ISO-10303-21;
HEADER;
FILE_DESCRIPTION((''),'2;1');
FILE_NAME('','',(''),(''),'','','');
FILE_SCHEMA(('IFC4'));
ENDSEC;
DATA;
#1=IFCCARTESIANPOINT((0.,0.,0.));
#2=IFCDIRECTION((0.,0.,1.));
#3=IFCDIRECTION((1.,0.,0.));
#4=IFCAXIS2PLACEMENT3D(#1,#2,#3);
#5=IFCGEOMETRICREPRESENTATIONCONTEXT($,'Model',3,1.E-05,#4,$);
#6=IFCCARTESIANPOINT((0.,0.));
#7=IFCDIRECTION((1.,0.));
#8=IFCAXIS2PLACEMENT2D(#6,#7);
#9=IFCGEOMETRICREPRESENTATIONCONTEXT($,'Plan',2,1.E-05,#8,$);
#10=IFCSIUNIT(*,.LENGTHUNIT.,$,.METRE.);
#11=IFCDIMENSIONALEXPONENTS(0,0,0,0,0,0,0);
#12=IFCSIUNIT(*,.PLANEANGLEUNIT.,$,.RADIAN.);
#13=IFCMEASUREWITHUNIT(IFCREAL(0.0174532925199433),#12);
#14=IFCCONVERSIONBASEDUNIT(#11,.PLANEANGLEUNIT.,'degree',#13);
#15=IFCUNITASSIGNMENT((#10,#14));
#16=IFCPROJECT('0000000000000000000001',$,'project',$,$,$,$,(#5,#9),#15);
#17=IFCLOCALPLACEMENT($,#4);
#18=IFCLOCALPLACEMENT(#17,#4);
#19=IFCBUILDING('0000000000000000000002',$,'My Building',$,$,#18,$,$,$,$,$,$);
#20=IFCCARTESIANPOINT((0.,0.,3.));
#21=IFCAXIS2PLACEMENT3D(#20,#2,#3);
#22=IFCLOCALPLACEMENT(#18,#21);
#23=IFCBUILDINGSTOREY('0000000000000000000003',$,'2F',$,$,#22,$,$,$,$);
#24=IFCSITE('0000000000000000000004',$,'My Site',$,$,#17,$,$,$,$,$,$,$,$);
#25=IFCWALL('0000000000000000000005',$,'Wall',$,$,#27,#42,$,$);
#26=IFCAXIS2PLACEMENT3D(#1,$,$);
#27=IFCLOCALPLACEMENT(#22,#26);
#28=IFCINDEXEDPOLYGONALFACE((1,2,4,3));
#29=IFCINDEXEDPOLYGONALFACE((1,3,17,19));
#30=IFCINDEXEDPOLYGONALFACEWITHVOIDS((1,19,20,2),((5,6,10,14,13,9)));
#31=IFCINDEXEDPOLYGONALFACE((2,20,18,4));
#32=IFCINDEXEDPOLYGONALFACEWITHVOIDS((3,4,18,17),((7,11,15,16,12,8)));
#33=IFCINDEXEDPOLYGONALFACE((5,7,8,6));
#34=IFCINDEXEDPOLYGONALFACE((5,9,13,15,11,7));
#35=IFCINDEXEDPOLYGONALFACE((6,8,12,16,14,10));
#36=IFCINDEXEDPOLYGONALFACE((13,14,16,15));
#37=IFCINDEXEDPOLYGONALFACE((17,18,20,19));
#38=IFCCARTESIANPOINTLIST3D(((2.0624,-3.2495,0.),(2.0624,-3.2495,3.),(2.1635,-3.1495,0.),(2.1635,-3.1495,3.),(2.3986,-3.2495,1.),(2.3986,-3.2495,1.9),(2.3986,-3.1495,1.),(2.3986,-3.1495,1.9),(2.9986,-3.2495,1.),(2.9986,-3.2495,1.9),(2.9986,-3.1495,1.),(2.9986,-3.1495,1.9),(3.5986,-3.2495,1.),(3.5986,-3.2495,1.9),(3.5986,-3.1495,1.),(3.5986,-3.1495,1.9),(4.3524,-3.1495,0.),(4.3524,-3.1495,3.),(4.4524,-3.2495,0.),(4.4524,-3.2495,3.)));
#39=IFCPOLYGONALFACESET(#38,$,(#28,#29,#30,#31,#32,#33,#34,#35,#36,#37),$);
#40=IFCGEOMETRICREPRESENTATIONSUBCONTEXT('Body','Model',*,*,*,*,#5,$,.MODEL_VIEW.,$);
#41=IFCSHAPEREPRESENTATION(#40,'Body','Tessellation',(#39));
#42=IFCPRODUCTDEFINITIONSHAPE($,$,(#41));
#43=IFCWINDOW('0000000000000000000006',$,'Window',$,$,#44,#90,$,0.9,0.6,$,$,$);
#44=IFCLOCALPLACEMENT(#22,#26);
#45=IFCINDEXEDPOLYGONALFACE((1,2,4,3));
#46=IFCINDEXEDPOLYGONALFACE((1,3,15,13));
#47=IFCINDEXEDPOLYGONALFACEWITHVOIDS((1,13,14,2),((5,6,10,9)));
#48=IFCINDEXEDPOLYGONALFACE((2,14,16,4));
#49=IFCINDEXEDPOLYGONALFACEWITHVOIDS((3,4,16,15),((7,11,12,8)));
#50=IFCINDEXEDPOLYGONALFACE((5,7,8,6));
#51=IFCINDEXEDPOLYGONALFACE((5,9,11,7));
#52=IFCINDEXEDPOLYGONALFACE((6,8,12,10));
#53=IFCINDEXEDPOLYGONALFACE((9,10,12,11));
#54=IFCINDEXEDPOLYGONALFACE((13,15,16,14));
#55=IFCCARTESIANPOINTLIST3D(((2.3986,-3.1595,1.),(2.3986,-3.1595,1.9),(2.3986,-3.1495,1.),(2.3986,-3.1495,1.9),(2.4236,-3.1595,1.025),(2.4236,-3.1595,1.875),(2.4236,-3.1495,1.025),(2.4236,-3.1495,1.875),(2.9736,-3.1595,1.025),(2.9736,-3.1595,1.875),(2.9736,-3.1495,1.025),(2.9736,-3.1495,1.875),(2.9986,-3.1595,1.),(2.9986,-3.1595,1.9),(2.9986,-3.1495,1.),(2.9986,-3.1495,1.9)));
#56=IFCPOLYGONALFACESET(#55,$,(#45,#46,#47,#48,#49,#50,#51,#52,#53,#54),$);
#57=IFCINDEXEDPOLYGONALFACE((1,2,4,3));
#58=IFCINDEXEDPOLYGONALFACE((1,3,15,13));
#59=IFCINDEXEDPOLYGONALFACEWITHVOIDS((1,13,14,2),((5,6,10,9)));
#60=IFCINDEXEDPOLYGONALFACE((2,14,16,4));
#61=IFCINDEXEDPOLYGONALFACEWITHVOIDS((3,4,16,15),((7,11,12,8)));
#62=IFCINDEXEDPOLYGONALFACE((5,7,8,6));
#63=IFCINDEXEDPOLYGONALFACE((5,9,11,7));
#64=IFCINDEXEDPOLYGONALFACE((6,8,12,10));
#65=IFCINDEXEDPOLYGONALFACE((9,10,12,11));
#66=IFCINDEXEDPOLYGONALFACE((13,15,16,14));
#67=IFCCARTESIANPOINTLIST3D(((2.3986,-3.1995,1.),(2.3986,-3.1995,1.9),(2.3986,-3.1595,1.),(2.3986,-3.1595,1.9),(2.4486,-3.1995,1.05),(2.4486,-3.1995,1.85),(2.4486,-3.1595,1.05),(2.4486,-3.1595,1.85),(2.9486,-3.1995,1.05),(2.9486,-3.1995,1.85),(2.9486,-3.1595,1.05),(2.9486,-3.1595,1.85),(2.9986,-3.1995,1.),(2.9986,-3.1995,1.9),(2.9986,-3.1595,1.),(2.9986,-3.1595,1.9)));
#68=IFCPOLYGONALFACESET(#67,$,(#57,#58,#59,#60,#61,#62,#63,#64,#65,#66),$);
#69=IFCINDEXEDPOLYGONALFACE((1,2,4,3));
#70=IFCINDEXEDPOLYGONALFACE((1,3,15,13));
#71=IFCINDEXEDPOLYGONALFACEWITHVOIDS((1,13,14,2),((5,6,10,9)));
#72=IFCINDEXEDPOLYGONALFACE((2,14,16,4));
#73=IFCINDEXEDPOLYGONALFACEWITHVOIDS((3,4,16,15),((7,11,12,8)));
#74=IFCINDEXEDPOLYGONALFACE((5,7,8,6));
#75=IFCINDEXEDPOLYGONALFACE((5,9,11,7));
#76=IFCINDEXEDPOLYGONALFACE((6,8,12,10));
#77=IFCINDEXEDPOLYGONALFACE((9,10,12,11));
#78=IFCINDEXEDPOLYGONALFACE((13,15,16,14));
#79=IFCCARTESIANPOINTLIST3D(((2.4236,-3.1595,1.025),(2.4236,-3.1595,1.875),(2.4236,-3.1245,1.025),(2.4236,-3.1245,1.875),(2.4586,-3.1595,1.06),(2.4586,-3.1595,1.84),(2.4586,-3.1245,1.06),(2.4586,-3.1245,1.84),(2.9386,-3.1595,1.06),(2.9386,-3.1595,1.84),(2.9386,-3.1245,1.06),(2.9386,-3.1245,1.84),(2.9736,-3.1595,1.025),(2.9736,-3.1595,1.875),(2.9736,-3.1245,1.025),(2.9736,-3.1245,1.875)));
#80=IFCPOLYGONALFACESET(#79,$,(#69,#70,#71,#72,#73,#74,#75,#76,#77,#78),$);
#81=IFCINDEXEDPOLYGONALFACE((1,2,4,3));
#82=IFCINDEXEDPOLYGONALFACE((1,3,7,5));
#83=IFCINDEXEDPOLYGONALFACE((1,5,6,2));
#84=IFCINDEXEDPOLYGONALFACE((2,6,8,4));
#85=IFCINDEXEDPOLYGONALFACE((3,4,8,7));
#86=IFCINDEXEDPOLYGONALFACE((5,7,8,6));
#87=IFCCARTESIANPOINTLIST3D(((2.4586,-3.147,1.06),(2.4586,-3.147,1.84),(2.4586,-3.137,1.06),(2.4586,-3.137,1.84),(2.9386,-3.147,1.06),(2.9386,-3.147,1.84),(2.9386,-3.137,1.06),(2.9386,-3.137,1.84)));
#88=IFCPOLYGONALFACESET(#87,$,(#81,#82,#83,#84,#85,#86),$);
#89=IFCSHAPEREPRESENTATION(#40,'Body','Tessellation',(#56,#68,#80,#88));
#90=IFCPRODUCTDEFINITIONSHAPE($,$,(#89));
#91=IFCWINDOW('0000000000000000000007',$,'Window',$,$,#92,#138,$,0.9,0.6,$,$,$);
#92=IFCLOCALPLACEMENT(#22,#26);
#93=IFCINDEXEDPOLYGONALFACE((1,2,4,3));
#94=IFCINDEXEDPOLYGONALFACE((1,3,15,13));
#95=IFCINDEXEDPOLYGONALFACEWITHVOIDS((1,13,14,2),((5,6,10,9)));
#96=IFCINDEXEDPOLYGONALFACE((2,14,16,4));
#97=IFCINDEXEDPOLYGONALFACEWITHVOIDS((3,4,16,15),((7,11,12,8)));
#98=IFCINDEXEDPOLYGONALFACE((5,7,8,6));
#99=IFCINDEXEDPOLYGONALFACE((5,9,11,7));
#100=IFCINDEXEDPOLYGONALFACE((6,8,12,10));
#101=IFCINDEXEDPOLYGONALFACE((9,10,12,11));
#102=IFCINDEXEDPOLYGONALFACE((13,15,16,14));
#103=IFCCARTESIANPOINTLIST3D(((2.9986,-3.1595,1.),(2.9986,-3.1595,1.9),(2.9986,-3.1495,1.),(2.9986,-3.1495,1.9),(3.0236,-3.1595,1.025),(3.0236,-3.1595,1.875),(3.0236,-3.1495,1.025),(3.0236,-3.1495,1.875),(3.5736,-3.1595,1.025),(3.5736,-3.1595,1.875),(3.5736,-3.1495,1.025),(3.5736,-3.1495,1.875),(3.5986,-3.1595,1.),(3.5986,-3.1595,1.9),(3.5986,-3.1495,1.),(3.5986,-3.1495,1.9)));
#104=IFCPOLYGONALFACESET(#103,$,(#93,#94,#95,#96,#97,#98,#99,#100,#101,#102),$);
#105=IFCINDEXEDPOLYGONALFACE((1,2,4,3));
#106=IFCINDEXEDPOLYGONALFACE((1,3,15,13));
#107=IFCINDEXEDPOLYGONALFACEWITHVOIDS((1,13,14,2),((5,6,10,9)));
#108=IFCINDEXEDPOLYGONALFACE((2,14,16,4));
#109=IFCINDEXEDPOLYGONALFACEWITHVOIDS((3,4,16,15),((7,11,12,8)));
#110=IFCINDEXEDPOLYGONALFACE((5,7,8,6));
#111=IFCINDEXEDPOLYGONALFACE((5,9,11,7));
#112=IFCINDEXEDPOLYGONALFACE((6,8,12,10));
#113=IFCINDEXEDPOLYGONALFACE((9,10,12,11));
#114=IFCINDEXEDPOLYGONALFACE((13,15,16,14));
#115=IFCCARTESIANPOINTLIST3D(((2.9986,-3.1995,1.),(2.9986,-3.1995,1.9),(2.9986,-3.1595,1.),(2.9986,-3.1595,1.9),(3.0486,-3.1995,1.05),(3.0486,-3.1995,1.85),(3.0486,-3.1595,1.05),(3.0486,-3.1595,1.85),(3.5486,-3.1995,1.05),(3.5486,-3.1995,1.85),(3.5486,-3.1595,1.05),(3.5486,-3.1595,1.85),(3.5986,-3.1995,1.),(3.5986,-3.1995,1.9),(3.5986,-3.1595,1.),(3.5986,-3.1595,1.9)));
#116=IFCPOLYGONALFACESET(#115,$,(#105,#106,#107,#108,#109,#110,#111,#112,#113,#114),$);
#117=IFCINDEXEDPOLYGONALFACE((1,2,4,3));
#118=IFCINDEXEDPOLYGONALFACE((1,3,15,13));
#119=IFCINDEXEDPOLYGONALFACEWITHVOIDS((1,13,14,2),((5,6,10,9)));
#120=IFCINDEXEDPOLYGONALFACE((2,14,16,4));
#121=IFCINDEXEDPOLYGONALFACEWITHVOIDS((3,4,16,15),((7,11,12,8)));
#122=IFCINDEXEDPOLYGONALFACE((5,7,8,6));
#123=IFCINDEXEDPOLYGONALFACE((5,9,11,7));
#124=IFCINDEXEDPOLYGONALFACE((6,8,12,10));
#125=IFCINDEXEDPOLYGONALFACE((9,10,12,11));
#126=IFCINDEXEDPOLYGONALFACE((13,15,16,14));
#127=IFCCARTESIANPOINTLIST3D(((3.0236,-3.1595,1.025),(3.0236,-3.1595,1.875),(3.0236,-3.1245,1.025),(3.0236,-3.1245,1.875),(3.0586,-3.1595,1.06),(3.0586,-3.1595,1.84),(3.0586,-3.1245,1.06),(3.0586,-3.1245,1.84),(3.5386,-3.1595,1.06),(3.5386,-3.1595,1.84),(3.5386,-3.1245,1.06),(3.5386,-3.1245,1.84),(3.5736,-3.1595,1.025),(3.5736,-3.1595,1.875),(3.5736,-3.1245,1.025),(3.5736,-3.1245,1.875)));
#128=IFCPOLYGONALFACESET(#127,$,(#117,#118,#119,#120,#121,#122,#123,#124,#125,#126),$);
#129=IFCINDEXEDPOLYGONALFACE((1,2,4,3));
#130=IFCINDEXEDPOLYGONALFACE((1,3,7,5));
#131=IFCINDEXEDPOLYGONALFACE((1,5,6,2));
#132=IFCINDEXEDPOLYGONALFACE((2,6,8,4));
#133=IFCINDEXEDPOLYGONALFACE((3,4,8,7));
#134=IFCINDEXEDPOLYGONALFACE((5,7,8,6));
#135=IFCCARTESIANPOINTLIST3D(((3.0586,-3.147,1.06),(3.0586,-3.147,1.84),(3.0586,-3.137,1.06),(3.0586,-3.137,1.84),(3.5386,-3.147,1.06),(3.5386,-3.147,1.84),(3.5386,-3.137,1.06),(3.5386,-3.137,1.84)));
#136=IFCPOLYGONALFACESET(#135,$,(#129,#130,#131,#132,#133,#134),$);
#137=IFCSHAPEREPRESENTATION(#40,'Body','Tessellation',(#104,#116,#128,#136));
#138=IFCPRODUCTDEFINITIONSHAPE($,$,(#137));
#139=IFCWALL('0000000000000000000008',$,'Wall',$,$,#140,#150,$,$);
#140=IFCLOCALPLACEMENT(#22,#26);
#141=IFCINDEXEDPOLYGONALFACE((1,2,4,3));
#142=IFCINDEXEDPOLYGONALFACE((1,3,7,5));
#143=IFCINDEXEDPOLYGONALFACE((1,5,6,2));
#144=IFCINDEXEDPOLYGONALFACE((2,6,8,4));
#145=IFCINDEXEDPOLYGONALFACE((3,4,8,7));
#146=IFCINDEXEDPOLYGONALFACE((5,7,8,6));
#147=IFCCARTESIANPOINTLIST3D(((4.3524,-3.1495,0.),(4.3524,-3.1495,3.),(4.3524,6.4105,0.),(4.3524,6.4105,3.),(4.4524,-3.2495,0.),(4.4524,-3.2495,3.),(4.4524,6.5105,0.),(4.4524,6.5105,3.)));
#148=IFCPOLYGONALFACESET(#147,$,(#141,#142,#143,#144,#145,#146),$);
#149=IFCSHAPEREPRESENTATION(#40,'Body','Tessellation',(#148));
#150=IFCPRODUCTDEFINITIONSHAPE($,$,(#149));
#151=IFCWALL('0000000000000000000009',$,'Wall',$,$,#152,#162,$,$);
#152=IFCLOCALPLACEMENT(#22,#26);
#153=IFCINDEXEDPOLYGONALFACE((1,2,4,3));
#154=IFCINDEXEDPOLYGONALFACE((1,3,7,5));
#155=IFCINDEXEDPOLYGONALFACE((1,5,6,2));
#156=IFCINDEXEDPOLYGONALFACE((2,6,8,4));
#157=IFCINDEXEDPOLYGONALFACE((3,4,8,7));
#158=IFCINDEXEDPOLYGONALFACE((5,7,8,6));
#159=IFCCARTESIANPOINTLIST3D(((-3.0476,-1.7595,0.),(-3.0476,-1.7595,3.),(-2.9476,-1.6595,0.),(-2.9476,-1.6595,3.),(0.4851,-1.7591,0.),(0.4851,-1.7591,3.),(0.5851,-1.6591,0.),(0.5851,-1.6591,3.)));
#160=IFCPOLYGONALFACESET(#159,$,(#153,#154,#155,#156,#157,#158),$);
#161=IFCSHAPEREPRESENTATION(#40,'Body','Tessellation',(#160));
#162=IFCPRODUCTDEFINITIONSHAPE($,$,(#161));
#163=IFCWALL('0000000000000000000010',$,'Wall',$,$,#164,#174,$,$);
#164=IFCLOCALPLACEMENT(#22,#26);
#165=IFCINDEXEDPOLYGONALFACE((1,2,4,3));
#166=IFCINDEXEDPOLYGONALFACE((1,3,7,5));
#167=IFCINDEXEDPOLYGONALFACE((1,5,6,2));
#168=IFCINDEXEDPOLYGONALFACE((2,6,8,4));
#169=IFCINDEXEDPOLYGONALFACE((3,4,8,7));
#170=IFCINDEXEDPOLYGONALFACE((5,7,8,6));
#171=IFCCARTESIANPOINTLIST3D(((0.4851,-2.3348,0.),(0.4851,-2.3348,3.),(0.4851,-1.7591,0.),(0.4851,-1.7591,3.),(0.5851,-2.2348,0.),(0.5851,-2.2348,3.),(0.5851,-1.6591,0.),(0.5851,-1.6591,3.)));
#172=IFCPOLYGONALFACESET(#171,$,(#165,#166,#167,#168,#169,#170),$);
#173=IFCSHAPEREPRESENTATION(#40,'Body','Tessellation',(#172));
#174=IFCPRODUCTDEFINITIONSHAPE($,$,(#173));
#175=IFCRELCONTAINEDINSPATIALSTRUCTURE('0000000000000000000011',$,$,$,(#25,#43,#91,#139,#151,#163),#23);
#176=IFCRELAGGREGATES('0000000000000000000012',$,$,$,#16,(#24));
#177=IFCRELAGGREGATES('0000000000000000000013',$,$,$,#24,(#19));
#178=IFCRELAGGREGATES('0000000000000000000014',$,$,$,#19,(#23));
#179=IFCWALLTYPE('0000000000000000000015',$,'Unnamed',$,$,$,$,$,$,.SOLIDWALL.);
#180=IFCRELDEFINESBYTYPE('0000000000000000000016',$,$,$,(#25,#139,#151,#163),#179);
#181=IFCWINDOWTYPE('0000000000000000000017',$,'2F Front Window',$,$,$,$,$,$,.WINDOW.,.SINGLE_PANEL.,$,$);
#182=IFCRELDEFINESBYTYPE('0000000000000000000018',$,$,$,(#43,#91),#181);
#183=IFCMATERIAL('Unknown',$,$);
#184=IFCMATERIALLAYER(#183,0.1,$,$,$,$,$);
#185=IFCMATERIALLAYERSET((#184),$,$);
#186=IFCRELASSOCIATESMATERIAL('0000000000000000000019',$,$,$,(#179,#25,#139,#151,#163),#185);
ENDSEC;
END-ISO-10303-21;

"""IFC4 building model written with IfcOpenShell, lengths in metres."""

from ifc_helpers import new_model, entity, si_unit, converted_unit, frame, origin_with_axes, origin_2d_with_axis, place, context, subcontext, project, spatial, line, indexed_curve, outline, extrude, shape, source, transform, mapped, material, layer, layer_set, layer_usage, type_object, type_shapes, element, fill, save


model = new_model("IFC4")

# Units and contexts
model_context = context("Model", 3, precision=1e-05, world=origin_with_axes())
plan_context = context("Plan", 2, precision=1e-05, world=origin_2d_with_axis())
body_context_1 = subcontext(model_context, "Body", "Model", "MODEL_VIEW")
body_context_2 = subcontext(plan_context, "Body", "Plan", "PLAN_VIEW")
ifc_project = project(units=[si_unit("LENGTHUNIT", "METRE"), converted_unit("PLANEANGLEUNIT", "degree", entity("IfcReal", 0.0174532925199433), si_unit("PLANEANGLEUNIT", "RADIAN"), dimensions=[0, 0, 0, 0, 0, 0, 0])], contexts=[model_context, plan_context])

# Site, building, storey
site_placement = place(None, origin_with_axes())
site = spatial("IfcSite", under=ifc_project, at=site_placement, Name="My Site")
building_placement = place(site_placement, origin_with_axes())
building = spatial("IfcBuilding", under=site, at=building_placement, Name="My Building")
storey_placement = place(building_placement, frame((0.0, 0.0, 3.0), z_axis=(0.0, 0.0, 1.0), x_axis=(1.0, 0.0, 0.0)))
storey = spatial("IfcBuildingStorey", under=building, at=storey_placement, Name="2F")

# Shared definitions
ifc_material = material(Name="Unknown")

# Wall, openings, windows
ifc_layer_1 = layer(ifc_material, 0.1)
ifc_layer_set_1 = layer_set([ifc_layer_1])
ifc_layer_usage_1 = layer_usage(ifc_layer_set_1, "AXIS2", "POSITIVE", 0.0)
wall_type = type_object("IfcWallType", Name="Unnamed", PredefinedType="SOLIDWALL", material=ifc_layer_set_1)
wall_1_placement = place(storey_placement, frame((2.0624, -3.2495, 0.0), z_axis=(0.0, 0.0, 1.0), x_axis=(1.0, 0.0, 0.0)))
wall_1 = element("IfcWall", 1, at=wall_1_placement, inside=storey, type_object=wall_type, material=ifc_layer_usage_1, Name="Wall", context=body_context_1, shape_type="SweptSolid", body=[
    extrude(outline(indexed_curve([(0.0, 0.0), (0.1011, 0.1), (2.29, 0.1), (2.39, 0.0)], segments=[line(1, 2, 3, 4, 1)])), origin_with_axes(), (0.0, 0.0, 1.0), 3.0),
])
shared_shape_1 = source(origin_with_axes(), body_context_1, "Body", "SweptSolid", [
    extrude(outline(indexed_curve([(0.0, 0.0), (0.6, 0.0), (0.6, 0.9), (0.0, 0.9)], segments=[line(1, 2, 3, 4, 1)])), frame((0.0, -0.6, 0.0), z_axis=(0.0, -1.0, 0.0), x_axis=(1.0, 0.0, 0.0)), (0.0, 0.0, -1.0), 1.2),
])
opening_1_placement = place(wall_1_placement, frame((0.3362, 0.0, 1.0), z_axis=(0.0, 0.0, 1.0), x_axis=(1.0, 0.0, 0.0)))
opening_1 = element("IfcOpeningElement", 2, at=opening_1_placement, cuts=wall_1, PredefinedType="OPENING", context=body_context_1, shape_type="MappedRepresentation", body=[
    mapped(shared_shape_1, transform((0.0, 0.0, 0.0), x_axis=(1.0, 0.0, 0.0), y_axis=(0.0, 1.0, 0.0), z_axis=(0.0, 0.0, 1.0), scale=1.0)),
])
opening_2_placement = place(wall_1_placement, frame((0.9362, 0.0, 1.0), z_axis=(0.0, 0.0, 1.0), x_axis=(1.0, 0.0, 0.0)))
opening_2 = element("IfcOpeningElement", 3, at=opening_2_placement, cuts=wall_1, PredefinedType="OPENING", context=body_context_1, shape_type="MappedRepresentation", body=[
    mapped(shared_shape_1, transform((0.0, 0.0, 0.0), x_axis=(1.0, 0.0, 0.0), y_axis=(0.0, 1.0, 0.0), z_axis=(0.0, 0.0, 1.0), scale=1.0)),
])
window_type = type_object("IfcWindowType", Name="2F Front Window", PartitioningType="SINGLE_PANEL", PredefinedType="WINDOW")
shared_shape_2 = source(origin_with_axes(), body_context_1, "Body", "SweptSolid", [
    extrude(outline(indexed_curve([(0.0, 0.0), (0.6, 0.0), (0.6, 0.9), (0.0, 0.9)], segments=[line(1, 2, 3, 4, 1)]), holes=[indexed_curve([(0.025, 0.025), (0.575, 0.025), (0.575, 0.875), (0.025, 0.875)], segments=[line(1, 2, 3, 4, 1)])]), frame((0.0, 0.09, 0.0), z_axis=(0.0, -1.0, 0.0), x_axis=(1.0, 0.0, 0.0)), (0.0, 0.0, -1.0), 0.01),
    extrude(outline(indexed_curve([(0.0, 0.0), (0.6, 0.0), (0.6, 0.9), (0.0, 0.9)], segments=[line(1, 2, 3, 4, 1)]), holes=[indexed_curve([(0.05, 0.05), (0.55, 0.05), (0.55, 0.85), (0.05, 0.85)], segments=[line(1, 2, 3, 4, 1)])]), frame((0.0, 0.05, 0.0), z_axis=(0.0, -1.0, 0.0), x_axis=(1.0, 0.0, 0.0)), (0.0, 0.0, -1.0), 0.04),
    extrude(outline(indexed_curve([(0.0, 0.0), (0.55, 0.0), (0.55, 0.85), (0.0, 0.85)], segments=[line(1, 2, 3, 4, 1)]), holes=[indexed_curve([(0.035, 0.035), (0.515, 0.035), (0.515, 0.815), (0.035, 0.815)], segments=[line(1, 2, 3, 4, 1)])]), frame((0.025, 0.09, 0.025), z_axis=(0.0, -1.0, 0.0), x_axis=(1.0, 0.0, 0.0)), (0.0, 0.0, -1.0), 0.035),
    extrude(outline(indexed_curve([(0.035, 0.035), (0.515, 0.035), (0.515, 0.815), (0.035, 0.815)], segments=[line(1, 2, 3, 4, 1)])), frame((0.025, 0.1025, 0.025), z_axis=(0.0, -1.0, 0.0), x_axis=(1.0, 0.0, 0.0)), (0.0, 0.0, -1.0), 0.01),
])
shared_shape_3 = source(origin_with_axes(), body_context_2, "Body", "Curve2D", [
    entity("IfcIndexedPolyCurve", entity("IfcCartesianPointList2D", [[0.05, 0.05], [0.55, 0.05]])),
    entity("IfcIndexedPolyCurve", entity("IfcCartesianPointList2D", [[0.0, 0.1], [0.025, 0.1], [0.025, 0.09], [0.05, 0.09], [0.05, 0.05], [0.0, 0.05]]), [entity("IfcLineIndex", [1, 2, 3, 4, 5, 6, 1])]),
    entity("IfcIndexedPolyCurve", entity("IfcCartesianPointList2D", [[0.6, 0.1], [0.575, 0.1], [0.575, 0.09], [0.55, 0.09], [0.55, 0.05], [0.6, 0.05]]), [entity("IfcLineIndex", [1, 2, 3, 4, 5, 6, 1])]),
    entity("IfcIndexedPolyCurve", entity("IfcCartesianPointList2D", [[0.025, 0.09], [0.06, 0.09], [0.06, 0.125], [0.025, 0.125]]), [entity("IfcLineIndex", [1, 2, 3, 4, 1])]),
    entity("IfcIndexedPolyCurve", entity("IfcCartesianPointList2D", [[0.575, 0.09], [0.54, 0.09], [0.54, 0.125], [0.575, 0.125]]), [entity("IfcLineIndex", [1, 2, 3, 4, 1])]),
    entity("IfcIndexedPolyCurve", entity("IfcCartesianPointList2D", [[0.06, 0.09], [0.54, 0.09]])),
    entity("IfcIndexedPolyCurve", entity("IfcCartesianPointList2D", [[0.06, 0.125], [0.54, 0.125]])),
    entity("IfcIndexedPolyCurve", entity("IfcCartesianPointList2D", [[0.06, 0.1075], [0.54, 0.1075]])),
])
type_shapes(window_type, [shared_shape_2, shared_shape_3])
window_1_placement = place(opening_1_placement, origin_with_axes())
window_1 = element("IfcWindow", 4, at=window_1_placement, inside=storey, type_object=window_type, Name="Window", OverallHeight=0.9, OverallWidth=0.6, shapes=[
    shape(body_context_1, "Body", "MappedRepresentation", [mapped(shared_shape_2, transform((0.0, 0.0, 0.0), x_axis=(1.0, 0.0, 0.0), y_axis=(0.0, 1.0, 0.0), z_axis=(0.0, 0.0, 1.0), scale=1.0))]),
    shape(body_context_2, "Body", "MappedRepresentation", [mapped(shared_shape_3, transform((0.0, 0.0, 0.0), x_axis=(1.0, 0.0, 0.0), y_axis=(0.0, 1.0, 0.0), z_axis=(0.0, 0.0, 1.0), scale=1.0))]),
])
fill(opening_1, window_1)
window_2_placement = place(opening_2_placement, origin_with_axes())
window_2 = element("IfcWindow", 5, at=window_2_placement, inside=storey, type_object=window_type, Name="Window", OverallHeight=0.9, OverallWidth=0.6, shapes=[
    shape(body_context_1, "Body", "MappedRepresentation", [mapped(shared_shape_2, transform((0.0, 0.0, 0.0), x_axis=(1.0, 0.0, 0.0), y_axis=(0.0, 1.0, 0.0), z_axis=(0.0, 0.0, 1.0), scale=1.0))]),
    shape(body_context_2, "Body", "MappedRepresentation", [mapped(shared_shape_3, transform((0.0, 0.0, 0.0), x_axis=(1.0, 0.0, 0.0), y_axis=(0.0, 1.0, 0.0), z_axis=(0.0, 0.0, 1.0), scale=1.0))]),
])
fill(opening_2, window_2)

# Walls
ifc_layer_usage_2 = layer_usage(ifc_layer_set_1, "AXIS2", "POSITIVE", 0.0)
wall_2_placement = place(storey_placement, frame((4.4524, -3.2495, 0.0), z_axis=(0.0, 0.0, 1.0), x_axis=(0.0, 1.0, 0.0)))
element("IfcWall", 6, at=wall_2_placement, inside=storey, type_object=wall_type, material=ifc_layer_usage_2, Name="Wall", context=body_context_1, shape_type="SweptSolid", body=[
    extrude(outline(indexed_curve([(0.0, 0.0), (0.1, 0.1), (9.66, 0.1), (9.76, 0.0)], segments=[line(1, 2, 3, 4, 1)])), origin_with_axes(), (0.0, 0.0, 1.0), 3.0),
])
ifc_layer_usage_3 = layer_usage(ifc_layer_set_1, "AXIS2", "POSITIVE", 0.0)
wall_3_placement = place(storey_placement, frame((-3.0476, -1.7595, 0.0), z_axis=(0.0, 0.0, 1.0), x_axis=(1.0, 0.000125, 0.0)))
element("IfcWall", 7, at=wall_3_placement, inside=storey, type_object=wall_type, material=ifc_layer_usage_3, Name="Wall", context=body_context_1, shape_type="SweptSolid", body=[
    extrude(outline(indexed_curve([(0.0, 0.0), (0.1, 0.1), (3.6327, 0.1), (3.5327, 0.0)], segments=[line(1, 2, 3, 4, 1)])), origin_with_axes(), (0.0, 0.0, 1.0), 3.0),
])
ifc_layer_usage_4 = layer_usage(ifc_layer_set_1, "AXIS2", "POSITIVE", 0.0)
wall_4_placement = place(storey_placement, frame((0.4851, -1.7591, 0.0), z_axis=(0.0, 0.0, 1.0), x_axis=(0.0, -1.0, 0.0)))
element("IfcWall", 8, at=wall_4_placement, inside=storey, type_object=wall_type, material=ifc_layer_usage_4, Name="Wall", context=body_context_1, shape_type="SweptSolid", body=[
    extrude(outline(indexed_curve([(0.0, 0.0), (-0.1, 0.1), (0.4757, 0.1), (0.5757, 0.0)], segments=[line(1, 2, 3, 4, 1)])), origin_with_axes(), (0.0, 0.0, 1.0), 3.0),
])

save(model, "model.ifc")
